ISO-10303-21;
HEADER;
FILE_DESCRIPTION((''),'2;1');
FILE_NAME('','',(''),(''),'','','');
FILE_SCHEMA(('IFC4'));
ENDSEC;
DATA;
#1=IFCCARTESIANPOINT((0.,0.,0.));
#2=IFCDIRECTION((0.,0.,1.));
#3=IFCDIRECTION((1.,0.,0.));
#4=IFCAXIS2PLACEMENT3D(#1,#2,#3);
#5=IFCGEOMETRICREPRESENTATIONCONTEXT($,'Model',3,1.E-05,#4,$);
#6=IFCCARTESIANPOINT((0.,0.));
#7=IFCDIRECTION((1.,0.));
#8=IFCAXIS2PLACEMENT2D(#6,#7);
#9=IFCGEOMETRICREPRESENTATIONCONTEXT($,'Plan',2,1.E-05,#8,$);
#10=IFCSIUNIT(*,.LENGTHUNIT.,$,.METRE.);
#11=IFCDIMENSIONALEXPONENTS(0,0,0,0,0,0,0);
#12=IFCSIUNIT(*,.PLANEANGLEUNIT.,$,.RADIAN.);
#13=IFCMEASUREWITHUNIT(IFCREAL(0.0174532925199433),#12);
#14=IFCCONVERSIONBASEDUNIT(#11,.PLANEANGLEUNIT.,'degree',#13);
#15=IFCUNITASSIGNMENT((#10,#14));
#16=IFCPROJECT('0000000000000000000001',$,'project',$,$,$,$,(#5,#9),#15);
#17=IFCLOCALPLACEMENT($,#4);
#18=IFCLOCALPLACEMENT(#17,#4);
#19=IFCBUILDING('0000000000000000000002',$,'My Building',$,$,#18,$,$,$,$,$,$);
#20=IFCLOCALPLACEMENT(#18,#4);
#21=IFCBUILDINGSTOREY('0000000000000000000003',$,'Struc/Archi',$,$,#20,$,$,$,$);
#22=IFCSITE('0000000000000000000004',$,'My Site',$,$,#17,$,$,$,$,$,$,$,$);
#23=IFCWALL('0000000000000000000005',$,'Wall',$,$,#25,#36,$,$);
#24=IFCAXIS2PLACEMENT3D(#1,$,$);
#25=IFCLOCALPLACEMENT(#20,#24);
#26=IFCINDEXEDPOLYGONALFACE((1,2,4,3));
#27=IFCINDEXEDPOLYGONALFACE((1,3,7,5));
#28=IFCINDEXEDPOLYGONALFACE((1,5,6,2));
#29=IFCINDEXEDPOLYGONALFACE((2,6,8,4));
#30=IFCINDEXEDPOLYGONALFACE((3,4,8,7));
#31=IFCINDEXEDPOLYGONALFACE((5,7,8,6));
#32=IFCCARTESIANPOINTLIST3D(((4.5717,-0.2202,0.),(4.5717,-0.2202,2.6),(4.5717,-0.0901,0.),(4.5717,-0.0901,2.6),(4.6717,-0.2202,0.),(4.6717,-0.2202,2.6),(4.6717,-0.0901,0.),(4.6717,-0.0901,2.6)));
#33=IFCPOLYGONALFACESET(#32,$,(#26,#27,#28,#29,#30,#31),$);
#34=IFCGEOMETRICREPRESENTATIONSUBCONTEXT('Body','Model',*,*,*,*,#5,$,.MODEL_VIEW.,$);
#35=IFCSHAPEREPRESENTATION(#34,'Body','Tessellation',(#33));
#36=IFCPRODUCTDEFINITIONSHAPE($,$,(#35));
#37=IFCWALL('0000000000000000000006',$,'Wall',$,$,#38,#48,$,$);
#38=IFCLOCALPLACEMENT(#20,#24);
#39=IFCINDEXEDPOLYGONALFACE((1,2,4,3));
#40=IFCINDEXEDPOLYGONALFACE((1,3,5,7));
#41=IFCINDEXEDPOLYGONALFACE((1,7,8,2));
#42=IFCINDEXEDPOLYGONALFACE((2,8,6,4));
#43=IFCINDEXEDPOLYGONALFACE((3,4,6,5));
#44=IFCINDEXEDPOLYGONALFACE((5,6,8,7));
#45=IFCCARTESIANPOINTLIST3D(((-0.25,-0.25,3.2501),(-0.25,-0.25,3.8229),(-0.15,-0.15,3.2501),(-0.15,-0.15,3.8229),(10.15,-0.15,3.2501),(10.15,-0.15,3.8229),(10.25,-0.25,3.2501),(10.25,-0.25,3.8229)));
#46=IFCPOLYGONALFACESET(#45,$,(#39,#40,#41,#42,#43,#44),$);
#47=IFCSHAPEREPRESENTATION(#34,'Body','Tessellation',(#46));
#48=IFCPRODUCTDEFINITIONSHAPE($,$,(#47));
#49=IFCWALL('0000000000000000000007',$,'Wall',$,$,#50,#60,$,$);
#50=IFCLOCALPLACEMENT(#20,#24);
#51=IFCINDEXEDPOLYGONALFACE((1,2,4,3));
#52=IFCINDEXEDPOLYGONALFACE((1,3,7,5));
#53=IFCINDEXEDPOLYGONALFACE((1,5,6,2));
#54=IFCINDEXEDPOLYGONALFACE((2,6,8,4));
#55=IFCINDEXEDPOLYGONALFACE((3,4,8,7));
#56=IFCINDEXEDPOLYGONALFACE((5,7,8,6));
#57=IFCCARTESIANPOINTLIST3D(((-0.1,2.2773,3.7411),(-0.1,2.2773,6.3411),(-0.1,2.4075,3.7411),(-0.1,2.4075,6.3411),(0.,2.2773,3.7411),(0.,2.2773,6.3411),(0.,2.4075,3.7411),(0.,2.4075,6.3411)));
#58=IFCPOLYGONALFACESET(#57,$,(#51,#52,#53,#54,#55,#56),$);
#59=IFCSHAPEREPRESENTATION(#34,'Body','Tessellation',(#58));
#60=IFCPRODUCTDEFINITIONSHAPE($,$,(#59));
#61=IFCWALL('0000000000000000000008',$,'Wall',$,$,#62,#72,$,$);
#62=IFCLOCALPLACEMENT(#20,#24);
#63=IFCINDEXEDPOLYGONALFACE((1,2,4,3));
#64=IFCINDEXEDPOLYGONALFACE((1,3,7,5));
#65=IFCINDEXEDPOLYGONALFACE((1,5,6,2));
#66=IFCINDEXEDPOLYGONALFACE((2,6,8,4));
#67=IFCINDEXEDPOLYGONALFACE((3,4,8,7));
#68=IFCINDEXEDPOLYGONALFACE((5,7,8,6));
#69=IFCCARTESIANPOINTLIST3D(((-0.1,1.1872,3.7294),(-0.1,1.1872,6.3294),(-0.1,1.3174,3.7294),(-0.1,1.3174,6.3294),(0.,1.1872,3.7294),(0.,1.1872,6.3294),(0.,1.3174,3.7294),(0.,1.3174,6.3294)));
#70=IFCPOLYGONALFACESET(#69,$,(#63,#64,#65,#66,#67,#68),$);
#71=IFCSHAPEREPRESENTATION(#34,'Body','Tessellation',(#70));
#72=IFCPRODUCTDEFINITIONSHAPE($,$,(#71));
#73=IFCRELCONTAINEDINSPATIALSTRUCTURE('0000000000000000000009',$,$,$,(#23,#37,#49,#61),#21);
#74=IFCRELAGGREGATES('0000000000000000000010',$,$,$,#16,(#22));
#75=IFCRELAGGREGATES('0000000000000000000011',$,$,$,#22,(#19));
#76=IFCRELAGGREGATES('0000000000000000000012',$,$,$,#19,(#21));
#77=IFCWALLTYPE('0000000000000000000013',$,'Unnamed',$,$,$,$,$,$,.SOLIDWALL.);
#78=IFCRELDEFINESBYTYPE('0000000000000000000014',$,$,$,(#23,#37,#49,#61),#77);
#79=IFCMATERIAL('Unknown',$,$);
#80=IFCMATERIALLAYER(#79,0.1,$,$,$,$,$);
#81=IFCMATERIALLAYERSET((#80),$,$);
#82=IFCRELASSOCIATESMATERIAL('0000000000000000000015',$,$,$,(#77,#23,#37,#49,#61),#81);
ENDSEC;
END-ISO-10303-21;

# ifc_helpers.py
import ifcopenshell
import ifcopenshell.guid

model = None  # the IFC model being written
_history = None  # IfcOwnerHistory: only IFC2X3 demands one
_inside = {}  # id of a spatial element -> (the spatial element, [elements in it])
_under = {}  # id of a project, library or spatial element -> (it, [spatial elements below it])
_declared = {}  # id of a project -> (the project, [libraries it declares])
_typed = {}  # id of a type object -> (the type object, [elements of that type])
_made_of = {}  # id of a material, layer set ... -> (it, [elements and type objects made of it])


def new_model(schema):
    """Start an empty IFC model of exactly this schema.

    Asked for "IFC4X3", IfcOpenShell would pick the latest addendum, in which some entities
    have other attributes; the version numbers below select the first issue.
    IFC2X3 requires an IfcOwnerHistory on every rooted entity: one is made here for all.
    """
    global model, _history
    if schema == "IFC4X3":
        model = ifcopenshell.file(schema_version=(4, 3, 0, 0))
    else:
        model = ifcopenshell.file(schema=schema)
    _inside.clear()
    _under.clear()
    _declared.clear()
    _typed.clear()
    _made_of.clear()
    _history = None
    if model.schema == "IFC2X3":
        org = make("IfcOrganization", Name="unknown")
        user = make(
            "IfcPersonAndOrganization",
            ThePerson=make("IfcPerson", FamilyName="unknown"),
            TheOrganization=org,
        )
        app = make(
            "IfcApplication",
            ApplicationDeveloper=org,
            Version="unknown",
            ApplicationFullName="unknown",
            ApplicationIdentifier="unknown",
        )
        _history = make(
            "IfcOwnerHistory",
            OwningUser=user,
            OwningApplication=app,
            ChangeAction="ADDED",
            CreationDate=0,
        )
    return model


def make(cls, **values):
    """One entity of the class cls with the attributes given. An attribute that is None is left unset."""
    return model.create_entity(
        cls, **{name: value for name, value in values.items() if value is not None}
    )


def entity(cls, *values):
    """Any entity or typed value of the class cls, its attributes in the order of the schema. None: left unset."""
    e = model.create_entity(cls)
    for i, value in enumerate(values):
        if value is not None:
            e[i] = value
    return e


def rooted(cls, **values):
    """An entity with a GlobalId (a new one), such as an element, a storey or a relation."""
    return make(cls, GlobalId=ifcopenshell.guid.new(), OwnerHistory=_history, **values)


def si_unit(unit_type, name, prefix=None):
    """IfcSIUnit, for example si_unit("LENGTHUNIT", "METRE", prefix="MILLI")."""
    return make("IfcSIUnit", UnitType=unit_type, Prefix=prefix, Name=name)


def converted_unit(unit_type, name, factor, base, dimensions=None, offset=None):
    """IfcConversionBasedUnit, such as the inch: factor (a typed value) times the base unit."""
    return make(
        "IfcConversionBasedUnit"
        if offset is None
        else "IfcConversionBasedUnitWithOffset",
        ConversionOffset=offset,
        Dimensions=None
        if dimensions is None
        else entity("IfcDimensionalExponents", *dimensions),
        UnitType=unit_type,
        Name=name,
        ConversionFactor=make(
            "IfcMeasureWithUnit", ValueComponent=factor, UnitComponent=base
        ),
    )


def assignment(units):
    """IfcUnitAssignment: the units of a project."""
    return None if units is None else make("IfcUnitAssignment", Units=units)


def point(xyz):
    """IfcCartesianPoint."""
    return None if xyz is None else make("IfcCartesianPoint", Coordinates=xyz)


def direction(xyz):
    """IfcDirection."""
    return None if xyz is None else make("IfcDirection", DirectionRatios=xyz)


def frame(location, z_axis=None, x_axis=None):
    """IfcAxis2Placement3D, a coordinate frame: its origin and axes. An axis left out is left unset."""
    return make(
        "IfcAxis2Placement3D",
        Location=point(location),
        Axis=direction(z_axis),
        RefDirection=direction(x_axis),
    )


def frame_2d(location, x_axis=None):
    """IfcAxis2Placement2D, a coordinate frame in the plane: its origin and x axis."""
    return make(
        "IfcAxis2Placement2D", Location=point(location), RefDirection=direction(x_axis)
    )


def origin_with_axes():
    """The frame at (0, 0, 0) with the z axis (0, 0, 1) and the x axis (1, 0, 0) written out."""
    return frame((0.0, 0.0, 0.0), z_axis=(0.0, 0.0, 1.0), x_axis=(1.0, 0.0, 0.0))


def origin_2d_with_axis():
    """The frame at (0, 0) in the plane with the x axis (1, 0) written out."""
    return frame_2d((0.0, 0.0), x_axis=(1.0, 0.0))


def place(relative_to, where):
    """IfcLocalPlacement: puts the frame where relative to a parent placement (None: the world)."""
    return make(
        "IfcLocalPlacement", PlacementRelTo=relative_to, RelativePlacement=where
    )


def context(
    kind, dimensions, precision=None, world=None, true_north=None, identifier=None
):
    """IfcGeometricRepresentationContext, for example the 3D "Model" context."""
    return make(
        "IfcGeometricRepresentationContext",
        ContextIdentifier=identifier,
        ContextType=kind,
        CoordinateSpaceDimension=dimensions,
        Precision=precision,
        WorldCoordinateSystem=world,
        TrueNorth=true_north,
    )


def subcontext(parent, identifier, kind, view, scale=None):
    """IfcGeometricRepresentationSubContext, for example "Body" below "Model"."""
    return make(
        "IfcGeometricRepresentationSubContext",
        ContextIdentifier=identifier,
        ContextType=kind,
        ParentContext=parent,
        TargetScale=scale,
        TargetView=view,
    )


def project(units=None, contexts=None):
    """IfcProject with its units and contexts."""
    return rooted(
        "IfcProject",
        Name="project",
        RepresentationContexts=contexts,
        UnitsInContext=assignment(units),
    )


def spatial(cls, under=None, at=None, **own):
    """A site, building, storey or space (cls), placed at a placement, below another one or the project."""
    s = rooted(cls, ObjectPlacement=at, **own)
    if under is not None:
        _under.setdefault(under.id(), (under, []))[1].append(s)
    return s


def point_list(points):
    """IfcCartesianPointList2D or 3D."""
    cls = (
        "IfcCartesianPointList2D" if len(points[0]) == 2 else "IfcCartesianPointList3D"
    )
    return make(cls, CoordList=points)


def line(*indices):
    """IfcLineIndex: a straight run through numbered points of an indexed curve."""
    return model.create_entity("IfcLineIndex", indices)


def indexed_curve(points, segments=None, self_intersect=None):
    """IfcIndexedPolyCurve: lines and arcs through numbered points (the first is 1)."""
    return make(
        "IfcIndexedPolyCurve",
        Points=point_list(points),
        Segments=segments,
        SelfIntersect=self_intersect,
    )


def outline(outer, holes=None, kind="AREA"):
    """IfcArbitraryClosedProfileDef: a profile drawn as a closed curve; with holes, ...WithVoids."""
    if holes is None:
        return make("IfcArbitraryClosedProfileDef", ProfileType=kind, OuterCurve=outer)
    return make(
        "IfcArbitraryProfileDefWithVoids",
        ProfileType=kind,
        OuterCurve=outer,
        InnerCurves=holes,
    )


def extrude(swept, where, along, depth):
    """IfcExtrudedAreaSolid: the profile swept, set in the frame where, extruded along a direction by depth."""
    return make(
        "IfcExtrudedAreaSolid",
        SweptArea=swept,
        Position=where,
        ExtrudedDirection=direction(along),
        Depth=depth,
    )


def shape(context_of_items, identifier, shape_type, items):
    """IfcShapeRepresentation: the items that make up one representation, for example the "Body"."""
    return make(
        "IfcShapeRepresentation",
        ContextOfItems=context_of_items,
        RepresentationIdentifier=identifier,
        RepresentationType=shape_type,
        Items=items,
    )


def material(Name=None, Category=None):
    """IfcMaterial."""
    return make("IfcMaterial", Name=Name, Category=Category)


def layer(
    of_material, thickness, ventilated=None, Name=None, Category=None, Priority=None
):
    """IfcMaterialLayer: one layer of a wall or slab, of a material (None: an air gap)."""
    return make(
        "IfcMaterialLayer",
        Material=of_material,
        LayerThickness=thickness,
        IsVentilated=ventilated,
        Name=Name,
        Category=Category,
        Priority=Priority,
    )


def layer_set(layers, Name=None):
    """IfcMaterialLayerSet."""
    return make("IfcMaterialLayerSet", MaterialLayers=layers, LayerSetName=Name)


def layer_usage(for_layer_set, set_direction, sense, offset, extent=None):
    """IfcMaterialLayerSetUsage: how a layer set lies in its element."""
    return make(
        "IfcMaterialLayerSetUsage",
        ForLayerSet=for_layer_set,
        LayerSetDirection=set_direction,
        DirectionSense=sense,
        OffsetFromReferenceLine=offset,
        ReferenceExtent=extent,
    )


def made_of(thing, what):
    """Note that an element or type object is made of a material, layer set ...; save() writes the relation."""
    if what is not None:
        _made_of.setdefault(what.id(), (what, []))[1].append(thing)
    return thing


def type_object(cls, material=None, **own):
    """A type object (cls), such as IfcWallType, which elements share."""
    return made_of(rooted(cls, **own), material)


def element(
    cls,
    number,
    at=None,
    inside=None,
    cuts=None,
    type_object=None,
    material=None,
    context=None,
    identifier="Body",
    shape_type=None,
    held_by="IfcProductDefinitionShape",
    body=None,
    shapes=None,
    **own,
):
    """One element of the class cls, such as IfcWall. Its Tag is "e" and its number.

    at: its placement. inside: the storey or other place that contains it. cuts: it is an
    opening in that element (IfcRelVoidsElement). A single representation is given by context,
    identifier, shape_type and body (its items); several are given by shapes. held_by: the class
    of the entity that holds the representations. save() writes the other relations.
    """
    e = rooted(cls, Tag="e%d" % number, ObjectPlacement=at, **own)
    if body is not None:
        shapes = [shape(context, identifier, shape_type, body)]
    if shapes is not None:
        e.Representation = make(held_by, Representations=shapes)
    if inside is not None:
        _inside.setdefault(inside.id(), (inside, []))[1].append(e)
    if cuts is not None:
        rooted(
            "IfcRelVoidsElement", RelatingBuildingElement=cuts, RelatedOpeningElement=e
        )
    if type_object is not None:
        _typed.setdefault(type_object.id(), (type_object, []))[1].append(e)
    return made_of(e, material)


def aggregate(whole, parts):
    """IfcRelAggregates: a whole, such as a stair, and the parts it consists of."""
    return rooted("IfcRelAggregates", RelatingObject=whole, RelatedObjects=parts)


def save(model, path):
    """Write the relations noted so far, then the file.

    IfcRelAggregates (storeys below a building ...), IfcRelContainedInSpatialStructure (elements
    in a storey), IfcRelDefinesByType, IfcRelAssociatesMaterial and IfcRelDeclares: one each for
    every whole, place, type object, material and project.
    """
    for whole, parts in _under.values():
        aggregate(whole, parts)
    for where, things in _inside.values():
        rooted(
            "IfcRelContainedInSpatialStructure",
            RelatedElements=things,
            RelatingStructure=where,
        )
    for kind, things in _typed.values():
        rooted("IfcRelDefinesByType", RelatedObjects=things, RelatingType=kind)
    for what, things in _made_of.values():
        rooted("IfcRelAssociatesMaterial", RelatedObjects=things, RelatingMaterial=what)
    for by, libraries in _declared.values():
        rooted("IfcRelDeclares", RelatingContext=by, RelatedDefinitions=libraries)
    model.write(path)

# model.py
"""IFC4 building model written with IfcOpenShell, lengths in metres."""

from ifc_helpers import new_model, entity, si_unit, converted_unit, frame, origin_with_axes, origin_2d_with_axis, place, context, subcontext, project, spatial, line, indexed_curve, outline, extrude, material, layer, layer_set, layer_usage, type_object, element, save


model = new_model("IFC4")

# Units and contexts
model_context = context("Model", 3, precision=1e-05, world=origin_with_axes())
plan_context = context("Plan", 2, precision=1e-05, world=origin_2d_with_axis())
body_context = subcontext(model_context, "Body", "Model", "MODEL_VIEW")
ifc_project = project(units=[si_unit("LENGTHUNIT", "METRE"), converted_unit("PLANEANGLEUNIT", "degree", entity("IfcReal", 0.0174532925199433), si_unit("PLANEANGLEUNIT", "RADIAN"), dimensions=[0, 0, 0, 0, 0, 0, 0])], contexts=[model_context, plan_context])

# Site, building, storey
site_placement = place(None, origin_with_axes())
site = spatial("IfcSite", under=ifc_project, at=site_placement, Name="My Site")
building_placement = place(site_placement, origin_with_axes())
building = spatial("IfcBuilding", under=site, at=building_placement, Name="My Building")
storey_placement = place(building_placement, origin_with_axes())
storey = spatial("IfcBuildingStorey", under=building, at=storey_placement, Name="Struc/Archi")

# Shared definitions
ifc_material = material(Name="Unknown")

# Walls
ifc_layer_1 = layer(ifc_material, 0.1)
ifc_layer_set_1 = layer_set([ifc_layer_1])
wall_type = type_object("IfcWallType", Name="Unnamed", PredefinedType="SOLIDWALL", material=ifc_layer_set_1)
ifc_layer_usage_1 = layer_usage(ifc_layer_set_1, "AXIS2", "POSITIVE", 0.0)
wall_1_placement = place(storey_placement, frame((4.5717, -0.0901, 0.0), z_axis=(0.0, 0.0, 1.0), x_axis=(0.0, -1.0, 0.0)))
element("IfcWall", 1, at=wall_1_placement, inside=storey, type_object=wall_type, material=ifc_layer_usage_1, Name="Wall", context=body_context, shape_type="SweptSolid", body=[
    extrude(outline(indexed_curve([(0.0, 0.0), (0.0, 0.1), (0.1301, 0.1), (0.1301, 0.0)], segments=[line(1, 2, 3, 4, 1)])), origin_with_axes(), (0.0, 0.0, 1.0), 2.6),
])
ifc_layer_usage_2 = layer_usage(ifc_layer_set_1, "AXIS2", "POSITIVE", 0.0)
wall_2_placement = place(storey_placement, frame((-0.25, -0.25, 3.2501), z_axis=(0.0, 0.0, 1.0), x_axis=(1.0, 0.0, 0.0)))
element("IfcWall", 2, at=wall_2_placement, inside=storey, type_object=wall_type, material=ifc_layer_usage_2, Name="Wall", context=body_context, shape_type="SweptSolid", body=[
    extrude(outline(indexed_curve([(0.0, 0.0), (0.1, 0.1), (10.4, 0.1), (10.5, 0.0)], segments=[line(1, 2, 3, 4, 1)])), origin_with_axes(), (0.0, 0.0, 1.0), 0.5728),
])
ifc_layer_usage_3 = layer_usage(ifc_layer_set_1, "AXIS2", "POSITIVE", 0.0)
wall_3_placement = place(storey_placement, frame((-0.1, 2.4075, 3.7411), z_axis=(0.0, 0.0, 1.0), x_axis=(0.0, -1.0, 0.0)))
element("IfcWall", 3, at=wall_3_placement, inside=storey, type_object=wall_type, material=ifc_layer_usage_3, Name="Wall", context=body_context, shape_type="SweptSolid", body=[
    extrude(outline(indexed_curve([(0.0, 0.0), (0.0, 0.1), (0.1301, 0.1), (0.1301, 0.0)], segments=[line(1, 2, 3, 4, 1)])), origin_with_axes(), (0.0, 0.0, 1.0), 2.6),
])
ifc_layer_usage_4 = layer_usage(ifc_layer_set_1, "AXIS2", "POSITIVE", 0.0)
wall_4_placement = place(storey_placement, frame((-0.1, 1.3174, 3.7294), z_axis=(0.0, 0.0, 1.0), x_axis=(0.0, -1.0, 0.0)))
element("IfcWall", 4, at=wall_4_placement, inside=storey, type_object=wall_type, material=ifc_layer_usage_4, Name="Wall", context=body_context, shape_type="SweptSolid", body=[
    extrude(outline(indexed_curve([(0.0, 0.0), (0.0, 0.1), (0.1301, 0.1), (0.1301, 0.0)], segments=[line(1, 2, 3, 4, 1)])), origin_with_axes(), (0.0, 0.0, 1.0), 2.6),
])

save(model, "model.ifc")
